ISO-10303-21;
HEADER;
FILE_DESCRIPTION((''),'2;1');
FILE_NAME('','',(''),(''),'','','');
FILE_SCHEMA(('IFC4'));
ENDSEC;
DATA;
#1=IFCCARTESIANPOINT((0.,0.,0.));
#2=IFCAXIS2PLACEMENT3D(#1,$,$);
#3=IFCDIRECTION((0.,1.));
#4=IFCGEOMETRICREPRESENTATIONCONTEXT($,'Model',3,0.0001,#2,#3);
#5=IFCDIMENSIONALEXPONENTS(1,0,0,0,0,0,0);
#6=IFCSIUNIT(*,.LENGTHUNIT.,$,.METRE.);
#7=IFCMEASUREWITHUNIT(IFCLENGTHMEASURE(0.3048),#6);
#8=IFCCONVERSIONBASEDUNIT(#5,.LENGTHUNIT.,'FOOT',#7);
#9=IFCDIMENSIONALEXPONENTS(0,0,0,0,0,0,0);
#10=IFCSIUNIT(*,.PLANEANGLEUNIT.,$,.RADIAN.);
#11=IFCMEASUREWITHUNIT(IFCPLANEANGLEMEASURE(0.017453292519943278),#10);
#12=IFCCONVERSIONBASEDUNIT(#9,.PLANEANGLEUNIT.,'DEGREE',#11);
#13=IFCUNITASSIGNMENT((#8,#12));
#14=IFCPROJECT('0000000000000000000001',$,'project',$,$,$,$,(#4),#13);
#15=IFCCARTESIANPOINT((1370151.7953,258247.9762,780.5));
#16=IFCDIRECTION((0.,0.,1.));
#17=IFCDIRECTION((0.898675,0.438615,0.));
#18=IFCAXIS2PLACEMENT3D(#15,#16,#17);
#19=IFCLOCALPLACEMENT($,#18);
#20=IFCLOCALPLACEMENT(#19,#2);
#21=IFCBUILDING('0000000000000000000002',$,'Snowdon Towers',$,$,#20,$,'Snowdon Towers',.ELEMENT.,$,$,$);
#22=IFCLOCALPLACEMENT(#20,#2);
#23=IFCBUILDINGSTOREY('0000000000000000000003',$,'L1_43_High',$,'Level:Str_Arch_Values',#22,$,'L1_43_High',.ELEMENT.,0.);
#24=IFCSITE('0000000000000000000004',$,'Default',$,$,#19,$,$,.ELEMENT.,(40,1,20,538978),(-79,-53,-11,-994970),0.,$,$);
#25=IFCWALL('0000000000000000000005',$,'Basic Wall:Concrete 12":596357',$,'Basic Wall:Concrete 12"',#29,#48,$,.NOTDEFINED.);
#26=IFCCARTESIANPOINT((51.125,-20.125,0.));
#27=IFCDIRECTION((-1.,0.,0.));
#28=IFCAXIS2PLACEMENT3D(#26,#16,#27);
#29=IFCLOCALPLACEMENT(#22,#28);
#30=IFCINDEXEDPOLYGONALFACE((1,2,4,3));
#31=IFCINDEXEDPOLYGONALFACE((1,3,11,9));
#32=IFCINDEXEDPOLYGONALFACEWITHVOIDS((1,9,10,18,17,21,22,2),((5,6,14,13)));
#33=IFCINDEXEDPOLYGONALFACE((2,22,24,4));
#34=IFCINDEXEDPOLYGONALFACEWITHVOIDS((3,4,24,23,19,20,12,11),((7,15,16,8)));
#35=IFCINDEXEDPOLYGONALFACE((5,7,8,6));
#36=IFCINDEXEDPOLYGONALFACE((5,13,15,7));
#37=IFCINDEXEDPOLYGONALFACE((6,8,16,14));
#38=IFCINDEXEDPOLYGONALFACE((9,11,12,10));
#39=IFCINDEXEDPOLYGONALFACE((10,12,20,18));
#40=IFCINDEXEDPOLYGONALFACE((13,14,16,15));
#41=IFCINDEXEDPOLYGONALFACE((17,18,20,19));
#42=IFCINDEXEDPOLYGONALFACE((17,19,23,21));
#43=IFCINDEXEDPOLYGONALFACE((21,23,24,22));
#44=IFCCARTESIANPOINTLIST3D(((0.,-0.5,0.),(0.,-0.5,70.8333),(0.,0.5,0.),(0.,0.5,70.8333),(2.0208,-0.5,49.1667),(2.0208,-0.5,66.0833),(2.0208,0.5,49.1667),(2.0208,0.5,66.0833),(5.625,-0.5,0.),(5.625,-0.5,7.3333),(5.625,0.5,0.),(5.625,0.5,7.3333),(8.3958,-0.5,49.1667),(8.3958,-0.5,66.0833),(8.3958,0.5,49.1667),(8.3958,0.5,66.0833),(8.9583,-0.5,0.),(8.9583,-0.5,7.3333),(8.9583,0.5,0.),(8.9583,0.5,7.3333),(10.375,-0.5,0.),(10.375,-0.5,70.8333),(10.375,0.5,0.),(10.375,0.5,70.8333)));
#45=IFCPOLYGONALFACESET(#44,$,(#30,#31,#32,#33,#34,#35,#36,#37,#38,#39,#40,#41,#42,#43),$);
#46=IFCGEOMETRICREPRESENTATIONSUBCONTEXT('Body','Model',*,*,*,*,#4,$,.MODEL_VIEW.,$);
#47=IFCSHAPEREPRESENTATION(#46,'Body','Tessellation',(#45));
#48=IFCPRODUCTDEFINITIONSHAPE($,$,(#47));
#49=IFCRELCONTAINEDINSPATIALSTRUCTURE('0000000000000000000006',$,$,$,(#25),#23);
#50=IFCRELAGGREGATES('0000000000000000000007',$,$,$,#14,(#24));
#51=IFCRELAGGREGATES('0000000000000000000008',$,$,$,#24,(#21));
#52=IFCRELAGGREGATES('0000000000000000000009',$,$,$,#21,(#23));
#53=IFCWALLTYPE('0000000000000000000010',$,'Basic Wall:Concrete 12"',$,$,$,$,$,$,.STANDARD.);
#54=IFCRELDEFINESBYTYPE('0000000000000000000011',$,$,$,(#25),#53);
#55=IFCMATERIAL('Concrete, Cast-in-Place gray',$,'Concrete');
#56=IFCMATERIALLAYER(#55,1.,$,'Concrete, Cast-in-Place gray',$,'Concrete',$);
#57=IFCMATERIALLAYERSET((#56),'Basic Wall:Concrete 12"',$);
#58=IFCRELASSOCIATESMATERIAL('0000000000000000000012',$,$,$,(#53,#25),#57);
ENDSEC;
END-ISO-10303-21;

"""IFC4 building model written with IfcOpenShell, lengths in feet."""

from ifc_helpers import new_model, entity, si_unit, converted_unit, direction, frame, frame_2d, origin, place, context, subcontext, project, spatial, rectangle, extrude, material, layer, layer_set, layer_usage, type_object, element, save


model = new_model("IFC4")

# Units and contexts
model_context = context("Model", 3, precision=0.0001, world=origin(), true_north=direction((0.0, 1.0)))
body_context = subcontext(model_context, "Body", "Model", "MODEL_VIEW")
ifc_project = project(units=[converted_unit("LENGTHUNIT", "FOOT", entity("IfcLengthMeasure", 0.3048), si_unit("LENGTHUNIT", "METRE"), dimensions=[1, 0, 0, 0, 0, 0, 0]), converted_unit("PLANEANGLEUNIT", "DEGREE", entity("IfcPlaneAngleMeasure", 0.017453292519943278), si_unit("PLANEANGLEUNIT", "RADIAN"), dimensions=[0, 0, 0, 0, 0, 0, 0])], contexts=[model_context])

# Site, building, storey
site_placement = place(None, frame((1370151.7953, 258247.9762, 780.5), z_axis=(0.0, 0.0, 1.0), x_axis=(0.898675, 0.438615, 0.0)))
site = spatial("IfcSite", under=ifc_project, at=site_placement, Name="Default", CompositionType="ELEMENT", RefLatitude=(40, 1, 20, 538978), RefLongitude=(-79, -53, -11, -994970), RefElevation=0.0)
building_placement = place(site_placement, origin())
building = spatial("IfcBuilding", under=site, at=building_placement, Name="Snowdon Towers", LongName="Snowdon Towers", CompositionType="ELEMENT")
storey_placement = place(building_placement, origin())
storey = spatial("IfcBuildingStorey", under=building, at=storey_placement, Name="L1_43_High", ObjectType="Level:Str_Arch_Values", LongName="L1_43_High", CompositionType="ELEMENT", Elevation=0.0)

# Wall, openings
ifc_material = material(Name="Concrete, Cast-in-Place gray", Category="Concrete")
ifc_layer = layer(ifc_material, 1.0, Name="Concrete, Cast-in-Place gray", Category="Concrete")
ifc_layer_set = layer_set([ifc_layer], Name="Basic Wall:Concrete 12\"")
wall_type = type_object("IfcWallType", Name="Basic Wall:Concrete 12\"", PredefinedType="STANDARD", material=ifc_layer_set)
ifc_layer_usage_1 = layer_usage(ifc_layer_set, "AXIS2", "POSITIVE", -0.5)
wall_1_placement = place(storey_placement, frame((51.125, -20.125, 0.0), z_axis=(0.0, 0.0, 1.0), x_axis=(-1.0, 0.0, 0.0)))
wall_1 = element("IfcWall", 1, at=wall_1_placement, inside=storey, type_object=wall_type, material=ifc_layer_usage_1, Name="Basic Wall:Concrete 12\":596357", ObjectType="Basic Wall:Concrete 12\"", PredefinedType="NOTDEFINED", context=body_context, shape_type="SweptSolid", body=[
    extrude(rectangle(XDim=10.375, YDim=1.0, at=frame_2d((5.1875, 0.0), x_axis=(-1.0, 0.0))), origin(), (0.0, 0.0, 1.0), 70.8333),
])
opening_1_placement = place(wall_1_placement, origin())
element("IfcOpeningElement", 2, at=opening_1_placement, cuts=wall_1, PredefinedType="OPENING", context=body_context, shape_type="SweptSolid", body=[
    extrude(rectangle(XDim=7.3333, YDim=3.3333, at=frame_2d((0.0, 0.0), x_axis=(1.0, 0.0))), frame((7.2917, -4.5, 3.6667), z_axis=(0.0, 1.0, 0.0), x_axis=(0.0, 0.0, 1.0)), (0.0, 0.0, 1.0), 10.0),
])
opening_2_placement = place(wall_1_placement, origin())
element("IfcOpeningElement", 3, at=opening_2_placement, cuts=wall_1, PredefinedType="OPENING", context=body_context, shape_type="SweptSolid", body=[
    extrude(rectangle(XDim=16.9167, YDim=6.375, at=frame_2d((0.0, 0.0), x_axis=(0.0, 1.0))), frame((5.2083, -5.5, 57.625), z_axis=(0.0, 1.0, 0.0), x_axis=(-1.0, 0.0, 0.0)), (0.0, 0.0, 1.0), 10.0),
])

save(model, "model.ifc")
